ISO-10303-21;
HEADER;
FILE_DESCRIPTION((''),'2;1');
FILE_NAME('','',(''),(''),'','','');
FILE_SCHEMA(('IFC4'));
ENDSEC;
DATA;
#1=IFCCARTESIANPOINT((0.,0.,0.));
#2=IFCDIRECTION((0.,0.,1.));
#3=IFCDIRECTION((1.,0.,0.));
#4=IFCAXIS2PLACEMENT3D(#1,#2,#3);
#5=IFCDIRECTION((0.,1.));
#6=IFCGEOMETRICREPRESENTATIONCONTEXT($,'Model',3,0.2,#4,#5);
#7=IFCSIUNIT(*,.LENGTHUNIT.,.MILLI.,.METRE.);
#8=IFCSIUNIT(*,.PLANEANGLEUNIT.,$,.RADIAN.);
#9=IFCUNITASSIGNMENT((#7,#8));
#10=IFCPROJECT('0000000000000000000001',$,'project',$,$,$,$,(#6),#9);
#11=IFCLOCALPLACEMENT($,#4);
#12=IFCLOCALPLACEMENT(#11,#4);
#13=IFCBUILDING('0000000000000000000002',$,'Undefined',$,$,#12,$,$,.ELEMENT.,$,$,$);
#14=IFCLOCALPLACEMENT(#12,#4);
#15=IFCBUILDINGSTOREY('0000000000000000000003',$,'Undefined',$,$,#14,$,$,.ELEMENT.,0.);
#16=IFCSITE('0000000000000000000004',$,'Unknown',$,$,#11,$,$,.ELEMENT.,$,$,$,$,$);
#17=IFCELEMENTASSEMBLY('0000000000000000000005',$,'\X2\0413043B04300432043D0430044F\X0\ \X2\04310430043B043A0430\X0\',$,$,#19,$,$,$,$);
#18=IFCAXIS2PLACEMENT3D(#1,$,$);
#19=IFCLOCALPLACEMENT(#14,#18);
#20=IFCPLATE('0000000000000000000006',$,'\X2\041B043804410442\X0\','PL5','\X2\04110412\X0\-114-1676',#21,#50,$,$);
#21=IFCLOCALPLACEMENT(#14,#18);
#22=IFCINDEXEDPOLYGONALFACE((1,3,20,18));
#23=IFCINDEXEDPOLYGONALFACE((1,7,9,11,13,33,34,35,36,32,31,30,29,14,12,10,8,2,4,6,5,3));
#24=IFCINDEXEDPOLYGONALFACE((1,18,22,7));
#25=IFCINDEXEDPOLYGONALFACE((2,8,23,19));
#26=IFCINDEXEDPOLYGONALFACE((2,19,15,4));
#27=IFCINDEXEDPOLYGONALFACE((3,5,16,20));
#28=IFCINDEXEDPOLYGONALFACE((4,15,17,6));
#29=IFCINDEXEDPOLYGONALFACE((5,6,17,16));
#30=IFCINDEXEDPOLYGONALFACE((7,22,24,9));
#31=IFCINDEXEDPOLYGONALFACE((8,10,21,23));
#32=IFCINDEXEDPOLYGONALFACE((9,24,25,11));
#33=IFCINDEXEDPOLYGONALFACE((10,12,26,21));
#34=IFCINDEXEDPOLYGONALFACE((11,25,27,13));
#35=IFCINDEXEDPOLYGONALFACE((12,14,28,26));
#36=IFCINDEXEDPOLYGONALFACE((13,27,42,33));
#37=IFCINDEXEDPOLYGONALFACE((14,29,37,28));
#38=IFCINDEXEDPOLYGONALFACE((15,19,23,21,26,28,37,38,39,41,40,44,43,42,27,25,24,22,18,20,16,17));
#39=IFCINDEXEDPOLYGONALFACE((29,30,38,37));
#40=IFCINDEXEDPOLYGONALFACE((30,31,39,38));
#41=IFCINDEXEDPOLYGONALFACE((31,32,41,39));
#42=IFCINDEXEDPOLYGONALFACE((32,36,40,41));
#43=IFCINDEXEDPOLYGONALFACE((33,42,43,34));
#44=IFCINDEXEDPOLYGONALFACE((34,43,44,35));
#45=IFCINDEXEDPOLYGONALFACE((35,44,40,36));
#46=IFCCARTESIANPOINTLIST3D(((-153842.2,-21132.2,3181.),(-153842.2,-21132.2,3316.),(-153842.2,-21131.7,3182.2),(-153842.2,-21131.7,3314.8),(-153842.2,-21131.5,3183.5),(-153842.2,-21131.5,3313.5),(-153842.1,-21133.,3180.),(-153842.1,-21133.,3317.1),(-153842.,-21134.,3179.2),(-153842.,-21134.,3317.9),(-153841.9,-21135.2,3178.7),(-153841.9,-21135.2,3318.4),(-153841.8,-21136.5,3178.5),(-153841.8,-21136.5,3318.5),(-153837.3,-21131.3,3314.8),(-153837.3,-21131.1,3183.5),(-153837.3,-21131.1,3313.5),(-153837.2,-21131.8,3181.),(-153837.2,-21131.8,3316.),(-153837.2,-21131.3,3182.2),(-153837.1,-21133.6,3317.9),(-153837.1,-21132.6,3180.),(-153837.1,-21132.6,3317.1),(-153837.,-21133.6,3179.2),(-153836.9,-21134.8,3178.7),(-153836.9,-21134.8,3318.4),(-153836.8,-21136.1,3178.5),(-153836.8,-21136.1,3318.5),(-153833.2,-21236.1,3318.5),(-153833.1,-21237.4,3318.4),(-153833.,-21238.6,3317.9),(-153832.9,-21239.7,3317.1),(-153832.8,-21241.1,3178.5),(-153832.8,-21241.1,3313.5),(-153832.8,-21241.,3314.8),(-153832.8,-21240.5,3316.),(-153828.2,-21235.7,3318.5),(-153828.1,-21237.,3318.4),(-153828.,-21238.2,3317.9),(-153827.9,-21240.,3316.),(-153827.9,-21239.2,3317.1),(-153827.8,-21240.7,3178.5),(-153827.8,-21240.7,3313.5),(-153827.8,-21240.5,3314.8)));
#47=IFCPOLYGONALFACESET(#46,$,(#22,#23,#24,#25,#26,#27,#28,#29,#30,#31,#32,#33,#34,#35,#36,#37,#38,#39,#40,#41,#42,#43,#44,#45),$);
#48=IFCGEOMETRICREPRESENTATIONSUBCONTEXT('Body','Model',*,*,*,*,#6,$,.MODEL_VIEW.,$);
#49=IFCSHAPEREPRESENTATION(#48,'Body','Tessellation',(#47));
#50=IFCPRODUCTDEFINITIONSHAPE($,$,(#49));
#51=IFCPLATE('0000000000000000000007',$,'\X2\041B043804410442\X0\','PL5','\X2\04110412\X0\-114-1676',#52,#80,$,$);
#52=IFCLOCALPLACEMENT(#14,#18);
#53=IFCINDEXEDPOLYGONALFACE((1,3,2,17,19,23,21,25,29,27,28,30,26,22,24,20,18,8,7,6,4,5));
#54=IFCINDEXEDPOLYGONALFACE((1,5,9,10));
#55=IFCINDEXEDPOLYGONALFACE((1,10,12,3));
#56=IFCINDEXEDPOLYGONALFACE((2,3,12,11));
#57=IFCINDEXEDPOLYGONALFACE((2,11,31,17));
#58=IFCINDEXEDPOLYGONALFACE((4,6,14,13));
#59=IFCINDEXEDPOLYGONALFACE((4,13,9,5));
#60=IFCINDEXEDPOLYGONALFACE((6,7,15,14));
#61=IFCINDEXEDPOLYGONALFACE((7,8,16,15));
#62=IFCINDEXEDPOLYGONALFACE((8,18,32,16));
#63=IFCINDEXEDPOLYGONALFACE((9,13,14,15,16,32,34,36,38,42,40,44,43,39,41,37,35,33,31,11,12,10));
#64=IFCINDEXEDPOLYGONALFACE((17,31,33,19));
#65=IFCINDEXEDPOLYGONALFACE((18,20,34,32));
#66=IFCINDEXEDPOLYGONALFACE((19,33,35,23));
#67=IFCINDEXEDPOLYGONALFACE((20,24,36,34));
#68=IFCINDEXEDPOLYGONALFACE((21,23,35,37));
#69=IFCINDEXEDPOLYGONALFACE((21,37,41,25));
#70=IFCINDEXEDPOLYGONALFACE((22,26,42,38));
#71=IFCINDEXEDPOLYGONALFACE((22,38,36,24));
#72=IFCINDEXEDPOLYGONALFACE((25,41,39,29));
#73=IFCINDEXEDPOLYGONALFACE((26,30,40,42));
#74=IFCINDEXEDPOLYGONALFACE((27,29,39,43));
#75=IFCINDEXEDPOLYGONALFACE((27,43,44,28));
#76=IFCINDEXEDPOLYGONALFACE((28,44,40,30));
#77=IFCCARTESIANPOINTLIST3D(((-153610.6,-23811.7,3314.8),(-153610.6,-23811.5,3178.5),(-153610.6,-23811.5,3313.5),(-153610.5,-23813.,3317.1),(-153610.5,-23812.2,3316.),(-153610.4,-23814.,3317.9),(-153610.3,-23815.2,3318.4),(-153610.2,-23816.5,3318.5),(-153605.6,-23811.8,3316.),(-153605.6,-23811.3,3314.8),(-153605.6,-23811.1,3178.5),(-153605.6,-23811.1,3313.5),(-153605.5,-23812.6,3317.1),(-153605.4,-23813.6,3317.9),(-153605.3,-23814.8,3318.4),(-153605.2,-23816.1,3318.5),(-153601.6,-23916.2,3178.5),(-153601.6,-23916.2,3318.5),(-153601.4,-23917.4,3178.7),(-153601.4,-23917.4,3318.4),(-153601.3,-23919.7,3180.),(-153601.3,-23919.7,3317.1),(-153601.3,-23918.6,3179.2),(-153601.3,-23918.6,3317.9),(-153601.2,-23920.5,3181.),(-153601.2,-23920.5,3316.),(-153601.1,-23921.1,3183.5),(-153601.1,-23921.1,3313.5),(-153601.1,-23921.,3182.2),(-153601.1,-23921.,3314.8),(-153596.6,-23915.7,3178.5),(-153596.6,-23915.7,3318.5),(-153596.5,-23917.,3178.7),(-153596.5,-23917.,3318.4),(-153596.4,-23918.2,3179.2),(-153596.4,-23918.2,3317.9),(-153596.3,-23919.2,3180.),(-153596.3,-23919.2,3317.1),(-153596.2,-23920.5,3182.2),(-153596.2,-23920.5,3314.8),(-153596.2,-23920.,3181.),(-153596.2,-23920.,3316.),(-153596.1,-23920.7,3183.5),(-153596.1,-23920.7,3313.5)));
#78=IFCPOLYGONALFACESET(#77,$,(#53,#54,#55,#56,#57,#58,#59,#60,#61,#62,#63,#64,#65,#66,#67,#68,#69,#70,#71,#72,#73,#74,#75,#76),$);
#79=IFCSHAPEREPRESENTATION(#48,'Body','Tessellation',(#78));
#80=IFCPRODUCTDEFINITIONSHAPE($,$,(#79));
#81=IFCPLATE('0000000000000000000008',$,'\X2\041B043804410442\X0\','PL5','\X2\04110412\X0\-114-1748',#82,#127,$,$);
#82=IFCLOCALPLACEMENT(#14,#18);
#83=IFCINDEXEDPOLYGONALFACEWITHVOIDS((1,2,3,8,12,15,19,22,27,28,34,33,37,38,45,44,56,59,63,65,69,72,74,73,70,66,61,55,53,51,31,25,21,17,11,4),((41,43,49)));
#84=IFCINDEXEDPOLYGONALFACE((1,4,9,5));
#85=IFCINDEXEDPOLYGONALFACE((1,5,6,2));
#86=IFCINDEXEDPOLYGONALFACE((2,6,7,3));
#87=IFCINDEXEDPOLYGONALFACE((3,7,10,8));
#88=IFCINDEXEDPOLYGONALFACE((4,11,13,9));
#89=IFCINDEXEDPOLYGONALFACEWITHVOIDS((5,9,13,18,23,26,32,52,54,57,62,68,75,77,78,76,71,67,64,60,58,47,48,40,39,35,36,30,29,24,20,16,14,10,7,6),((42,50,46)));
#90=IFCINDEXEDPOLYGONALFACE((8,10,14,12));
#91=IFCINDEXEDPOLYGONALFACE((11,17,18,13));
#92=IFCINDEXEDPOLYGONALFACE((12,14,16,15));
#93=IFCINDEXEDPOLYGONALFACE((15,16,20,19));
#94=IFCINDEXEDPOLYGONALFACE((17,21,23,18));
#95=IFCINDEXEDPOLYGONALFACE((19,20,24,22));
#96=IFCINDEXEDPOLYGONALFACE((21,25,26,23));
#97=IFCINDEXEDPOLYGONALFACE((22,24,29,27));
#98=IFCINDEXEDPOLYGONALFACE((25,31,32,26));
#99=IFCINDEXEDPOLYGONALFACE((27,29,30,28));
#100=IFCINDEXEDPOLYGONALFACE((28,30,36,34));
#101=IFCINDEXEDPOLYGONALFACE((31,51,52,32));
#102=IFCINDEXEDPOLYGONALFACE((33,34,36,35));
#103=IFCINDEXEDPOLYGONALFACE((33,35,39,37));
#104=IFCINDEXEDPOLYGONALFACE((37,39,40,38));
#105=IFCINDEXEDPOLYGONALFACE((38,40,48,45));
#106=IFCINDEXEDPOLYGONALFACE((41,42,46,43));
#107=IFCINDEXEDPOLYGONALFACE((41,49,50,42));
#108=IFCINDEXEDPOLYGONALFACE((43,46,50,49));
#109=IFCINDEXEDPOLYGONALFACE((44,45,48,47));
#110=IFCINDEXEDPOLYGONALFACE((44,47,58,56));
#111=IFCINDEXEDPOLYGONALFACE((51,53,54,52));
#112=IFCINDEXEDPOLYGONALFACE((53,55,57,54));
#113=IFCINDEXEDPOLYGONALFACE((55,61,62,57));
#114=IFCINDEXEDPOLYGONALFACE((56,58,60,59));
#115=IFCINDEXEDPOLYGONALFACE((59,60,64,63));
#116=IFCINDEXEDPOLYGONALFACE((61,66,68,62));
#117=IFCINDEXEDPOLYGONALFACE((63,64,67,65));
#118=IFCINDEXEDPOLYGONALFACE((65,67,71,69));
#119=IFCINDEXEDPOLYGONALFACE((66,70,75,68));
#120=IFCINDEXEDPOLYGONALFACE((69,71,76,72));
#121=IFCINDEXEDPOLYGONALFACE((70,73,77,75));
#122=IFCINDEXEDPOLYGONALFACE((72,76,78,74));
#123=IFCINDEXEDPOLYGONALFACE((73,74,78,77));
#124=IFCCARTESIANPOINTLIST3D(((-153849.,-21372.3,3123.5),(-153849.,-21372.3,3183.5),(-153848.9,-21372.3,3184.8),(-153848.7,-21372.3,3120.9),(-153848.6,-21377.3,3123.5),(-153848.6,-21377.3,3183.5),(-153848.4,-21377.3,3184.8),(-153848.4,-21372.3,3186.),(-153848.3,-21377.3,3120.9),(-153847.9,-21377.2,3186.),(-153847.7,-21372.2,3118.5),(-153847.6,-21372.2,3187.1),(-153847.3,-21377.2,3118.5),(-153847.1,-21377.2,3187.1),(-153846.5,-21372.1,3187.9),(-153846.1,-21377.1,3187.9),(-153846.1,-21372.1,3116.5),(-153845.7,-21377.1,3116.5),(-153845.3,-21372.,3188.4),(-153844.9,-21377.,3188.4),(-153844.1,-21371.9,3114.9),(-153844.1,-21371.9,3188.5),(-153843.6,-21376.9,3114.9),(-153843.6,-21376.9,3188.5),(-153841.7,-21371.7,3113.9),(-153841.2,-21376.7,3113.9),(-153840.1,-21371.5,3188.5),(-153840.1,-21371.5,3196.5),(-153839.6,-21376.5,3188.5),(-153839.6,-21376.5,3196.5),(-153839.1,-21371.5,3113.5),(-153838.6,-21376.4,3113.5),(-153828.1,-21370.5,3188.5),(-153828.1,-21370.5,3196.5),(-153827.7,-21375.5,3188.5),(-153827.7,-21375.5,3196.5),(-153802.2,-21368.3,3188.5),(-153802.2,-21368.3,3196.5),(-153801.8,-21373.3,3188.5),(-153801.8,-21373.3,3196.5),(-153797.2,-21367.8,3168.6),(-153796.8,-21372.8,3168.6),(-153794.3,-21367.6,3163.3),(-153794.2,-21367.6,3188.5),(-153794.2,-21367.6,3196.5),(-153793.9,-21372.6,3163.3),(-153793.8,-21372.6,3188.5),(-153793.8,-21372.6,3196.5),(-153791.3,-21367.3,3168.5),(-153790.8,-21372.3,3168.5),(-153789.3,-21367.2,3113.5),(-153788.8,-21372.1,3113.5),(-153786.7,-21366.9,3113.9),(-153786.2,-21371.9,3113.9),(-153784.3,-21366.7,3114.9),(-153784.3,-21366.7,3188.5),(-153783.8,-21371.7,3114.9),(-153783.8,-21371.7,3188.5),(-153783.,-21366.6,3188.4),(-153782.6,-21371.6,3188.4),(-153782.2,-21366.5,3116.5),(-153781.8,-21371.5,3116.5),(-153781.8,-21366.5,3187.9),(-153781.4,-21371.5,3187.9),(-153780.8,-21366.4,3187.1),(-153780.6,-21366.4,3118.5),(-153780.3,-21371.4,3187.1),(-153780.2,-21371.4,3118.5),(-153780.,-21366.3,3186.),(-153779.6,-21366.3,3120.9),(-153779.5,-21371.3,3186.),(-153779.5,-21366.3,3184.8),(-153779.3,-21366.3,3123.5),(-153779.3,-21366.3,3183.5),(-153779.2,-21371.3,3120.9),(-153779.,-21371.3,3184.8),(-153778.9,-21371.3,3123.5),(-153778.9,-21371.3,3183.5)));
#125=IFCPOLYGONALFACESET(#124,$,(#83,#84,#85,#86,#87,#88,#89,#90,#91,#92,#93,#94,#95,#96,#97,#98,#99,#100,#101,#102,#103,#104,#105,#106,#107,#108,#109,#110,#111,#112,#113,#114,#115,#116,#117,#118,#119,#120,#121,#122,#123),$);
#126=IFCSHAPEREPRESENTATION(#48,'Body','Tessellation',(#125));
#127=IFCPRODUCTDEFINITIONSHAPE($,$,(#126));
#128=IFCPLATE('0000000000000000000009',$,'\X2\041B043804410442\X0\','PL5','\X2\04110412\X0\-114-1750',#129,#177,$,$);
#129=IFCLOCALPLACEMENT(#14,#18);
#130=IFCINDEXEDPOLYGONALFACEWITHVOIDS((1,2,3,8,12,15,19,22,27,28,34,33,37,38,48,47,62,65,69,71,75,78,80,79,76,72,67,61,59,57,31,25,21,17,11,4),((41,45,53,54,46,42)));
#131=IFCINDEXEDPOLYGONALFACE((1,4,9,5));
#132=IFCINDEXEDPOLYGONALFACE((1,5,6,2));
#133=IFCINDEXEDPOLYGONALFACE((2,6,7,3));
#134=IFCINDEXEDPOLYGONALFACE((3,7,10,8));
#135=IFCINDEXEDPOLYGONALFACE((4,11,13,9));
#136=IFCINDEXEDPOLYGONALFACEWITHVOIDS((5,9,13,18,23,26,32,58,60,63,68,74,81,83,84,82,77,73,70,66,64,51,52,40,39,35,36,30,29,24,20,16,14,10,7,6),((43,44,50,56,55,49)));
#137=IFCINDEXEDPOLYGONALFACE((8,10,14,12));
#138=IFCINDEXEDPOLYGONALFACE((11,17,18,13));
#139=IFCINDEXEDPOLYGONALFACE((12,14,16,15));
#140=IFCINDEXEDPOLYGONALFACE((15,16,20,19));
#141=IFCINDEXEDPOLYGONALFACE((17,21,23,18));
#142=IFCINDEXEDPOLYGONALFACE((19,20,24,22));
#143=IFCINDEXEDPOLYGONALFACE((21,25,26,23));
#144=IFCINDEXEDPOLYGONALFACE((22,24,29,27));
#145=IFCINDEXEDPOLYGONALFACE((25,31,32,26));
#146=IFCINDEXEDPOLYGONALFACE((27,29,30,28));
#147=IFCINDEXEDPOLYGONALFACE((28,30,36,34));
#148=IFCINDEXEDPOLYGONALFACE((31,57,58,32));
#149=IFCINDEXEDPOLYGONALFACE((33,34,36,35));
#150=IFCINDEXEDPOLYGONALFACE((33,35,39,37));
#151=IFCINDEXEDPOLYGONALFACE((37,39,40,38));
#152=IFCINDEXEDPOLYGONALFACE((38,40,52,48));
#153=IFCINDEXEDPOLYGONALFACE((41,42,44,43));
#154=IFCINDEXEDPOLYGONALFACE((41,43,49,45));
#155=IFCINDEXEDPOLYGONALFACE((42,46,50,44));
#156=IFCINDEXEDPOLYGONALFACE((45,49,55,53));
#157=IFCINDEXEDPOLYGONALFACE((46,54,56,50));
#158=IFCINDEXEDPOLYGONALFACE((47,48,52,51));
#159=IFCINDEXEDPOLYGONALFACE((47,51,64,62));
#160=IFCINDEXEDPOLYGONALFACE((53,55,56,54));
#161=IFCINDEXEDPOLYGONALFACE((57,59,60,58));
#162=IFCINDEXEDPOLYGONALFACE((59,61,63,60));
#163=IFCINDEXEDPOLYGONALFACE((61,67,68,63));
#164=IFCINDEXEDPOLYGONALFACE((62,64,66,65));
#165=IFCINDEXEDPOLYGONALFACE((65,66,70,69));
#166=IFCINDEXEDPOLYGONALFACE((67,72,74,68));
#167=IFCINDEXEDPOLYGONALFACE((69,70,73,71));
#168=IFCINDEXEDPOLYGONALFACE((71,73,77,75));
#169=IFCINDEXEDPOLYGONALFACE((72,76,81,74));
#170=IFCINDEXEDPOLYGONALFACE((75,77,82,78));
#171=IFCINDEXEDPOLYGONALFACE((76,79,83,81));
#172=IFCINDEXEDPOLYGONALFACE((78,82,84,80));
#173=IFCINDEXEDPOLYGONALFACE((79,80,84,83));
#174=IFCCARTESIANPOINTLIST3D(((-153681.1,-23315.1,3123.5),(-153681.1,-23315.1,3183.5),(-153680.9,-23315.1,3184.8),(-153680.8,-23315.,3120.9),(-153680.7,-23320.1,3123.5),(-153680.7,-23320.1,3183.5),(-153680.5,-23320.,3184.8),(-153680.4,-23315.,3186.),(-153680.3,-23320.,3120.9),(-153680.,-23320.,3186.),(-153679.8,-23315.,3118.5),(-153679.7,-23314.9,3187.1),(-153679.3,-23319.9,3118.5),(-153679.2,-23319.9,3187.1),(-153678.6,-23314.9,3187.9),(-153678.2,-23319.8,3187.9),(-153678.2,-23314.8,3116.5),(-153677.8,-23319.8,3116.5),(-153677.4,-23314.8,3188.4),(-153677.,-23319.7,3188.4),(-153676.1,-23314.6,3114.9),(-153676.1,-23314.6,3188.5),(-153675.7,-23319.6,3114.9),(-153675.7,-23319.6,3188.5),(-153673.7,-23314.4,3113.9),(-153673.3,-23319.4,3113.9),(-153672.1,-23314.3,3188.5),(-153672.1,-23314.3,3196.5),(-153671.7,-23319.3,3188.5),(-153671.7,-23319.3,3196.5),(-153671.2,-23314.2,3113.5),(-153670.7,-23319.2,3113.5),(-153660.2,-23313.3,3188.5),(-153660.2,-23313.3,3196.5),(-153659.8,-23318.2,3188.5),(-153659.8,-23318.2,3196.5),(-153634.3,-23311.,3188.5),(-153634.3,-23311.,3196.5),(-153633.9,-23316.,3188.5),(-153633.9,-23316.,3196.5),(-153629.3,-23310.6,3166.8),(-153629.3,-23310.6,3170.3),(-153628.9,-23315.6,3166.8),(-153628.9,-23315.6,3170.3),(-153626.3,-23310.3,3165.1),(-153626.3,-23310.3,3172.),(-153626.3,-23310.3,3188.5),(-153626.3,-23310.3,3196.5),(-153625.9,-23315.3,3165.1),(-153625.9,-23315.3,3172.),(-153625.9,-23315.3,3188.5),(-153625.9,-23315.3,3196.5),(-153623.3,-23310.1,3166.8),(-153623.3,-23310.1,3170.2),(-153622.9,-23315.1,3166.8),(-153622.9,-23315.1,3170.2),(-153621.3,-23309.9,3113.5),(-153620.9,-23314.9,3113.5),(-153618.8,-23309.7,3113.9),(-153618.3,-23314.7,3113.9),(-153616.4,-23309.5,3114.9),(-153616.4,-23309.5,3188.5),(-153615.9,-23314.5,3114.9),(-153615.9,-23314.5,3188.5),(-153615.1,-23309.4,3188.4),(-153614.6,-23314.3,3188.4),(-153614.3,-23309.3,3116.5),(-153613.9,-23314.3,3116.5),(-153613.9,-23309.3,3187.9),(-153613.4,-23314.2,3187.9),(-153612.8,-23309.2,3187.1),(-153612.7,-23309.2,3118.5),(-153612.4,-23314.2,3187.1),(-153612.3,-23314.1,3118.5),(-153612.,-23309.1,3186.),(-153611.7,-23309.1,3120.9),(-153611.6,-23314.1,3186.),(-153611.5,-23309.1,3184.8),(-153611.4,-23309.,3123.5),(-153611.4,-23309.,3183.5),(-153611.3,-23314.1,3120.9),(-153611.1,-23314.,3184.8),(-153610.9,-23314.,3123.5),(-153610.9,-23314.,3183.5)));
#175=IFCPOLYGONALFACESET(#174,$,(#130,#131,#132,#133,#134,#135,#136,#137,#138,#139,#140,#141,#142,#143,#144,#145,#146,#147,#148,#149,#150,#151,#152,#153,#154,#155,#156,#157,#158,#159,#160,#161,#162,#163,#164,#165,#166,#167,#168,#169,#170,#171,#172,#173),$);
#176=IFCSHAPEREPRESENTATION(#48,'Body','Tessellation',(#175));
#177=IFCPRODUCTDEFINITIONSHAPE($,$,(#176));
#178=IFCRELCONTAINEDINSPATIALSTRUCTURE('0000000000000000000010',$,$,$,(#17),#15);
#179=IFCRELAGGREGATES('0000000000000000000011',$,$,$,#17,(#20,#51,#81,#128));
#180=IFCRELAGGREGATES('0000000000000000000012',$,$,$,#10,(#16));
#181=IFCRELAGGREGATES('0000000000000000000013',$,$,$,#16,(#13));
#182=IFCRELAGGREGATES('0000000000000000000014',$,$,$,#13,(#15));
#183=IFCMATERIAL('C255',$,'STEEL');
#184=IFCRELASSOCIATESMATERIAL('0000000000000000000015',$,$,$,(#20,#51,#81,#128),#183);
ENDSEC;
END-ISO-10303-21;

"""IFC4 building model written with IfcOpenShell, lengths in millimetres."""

from ifc_helpers import new_model, si_unit, direction, frame, origin_with_axes, place, context, subcontext, project, spatial, line, arc, indexed_curve, outline, extrude, material, element, aggregate, save


model = new_model("IFC4")

# Units and contexts
model_context = context("Model", 3, precision=0.2, world=origin_with_axes(), true_north=direction((0.0, 1.0)))
body_context = subcontext(model_context, "Body", "Model", "MODEL_VIEW")
ifc_project = project(units=[si_unit("LENGTHUNIT", "METRE", prefix="MILLI"), si_unit("PLANEANGLEUNIT", "RADIAN")], contexts=[model_context])

# Site, building, storey
site_placement = place(None, origin_with_axes())
site = spatial("IfcSite", under=ifc_project, at=site_placement, Name="Unknown", CompositionType="ELEMENT")
building_placement = place(site_placement, origin_with_axes())
building = spatial("IfcBuilding", under=site, at=building_placement, Name="Undefined", CompositionType="ELEMENT")
storey_placement = place(building_placement, origin_with_axes())
storey = spatial("IfcBuildingStorey", under=building, at=storey_placement, Name="Undefined", CompositionType="ELEMENT", Elevation=0.0)

# Element assembly, plates, voiding features
ifc_material_1 = material(Name="C255", Category="STEEL")
assembly_1_placement = place(storey_placement, frame((-153597.5, -23933.9, 3248.5), z_axis=(-0.996285, -0.086114, -0.000024), x_axis=(-0.086114, 0.996285, 0.0)))
assembly_1 = element("IfcElementAssembly", 1, at=assembly_1_placement, inside=storey, Name="Главная балка")
plate_1_placement = place(assembly_1_placement, frame((2813.0, -70.0, 0.0), z_axis=(0.0, 0.0, 1.0), x_axis=(0.0, 1.0, 0.0)))
plate_1 = element("IfcPlate", 2, at=plate_1_placement, material=ifc_material_1, Name="Лист", Description="PL5", ObjectType="БВ-114-1676", context=body_context, shape_type="SolidModel", body=[
    extrude(outline(indexed_curve([(0.0, 5.0), (1.5, 1.5), (5.0, 0.0), (135.0, 0.0), (138.5, 1.5), (140.0, 5.0), (140.0, 110.0), (5.0, 110.0), (1.5, 108.5), (0.0, 105.0)], segments=[arc(1, 2, 3), line(3, 4), arc(4, 5, 6), line(6, 7, 8), arc(8, 9, 10), line(10, 1)])), frame((0.0, 0.0, 2.5), z_axis=(0.0, 0.0, 1.0), x_axis=(1.0, 0.0, 0.0)), (0.0, 0.0, -1.0), 5.0),
])
plate_2_placement = place(assembly_1_placement, frame((13.0, -70.0, 0.0), z_axis=(0.0, 0.0, -1.0), x_axis=(0.0, 1.0, 0.0)))
plate_2 = element("IfcPlate", 3, at=plate_2_placement, material=ifc_material_1, Name="Лист", Description="PL5", ObjectType="БВ-114-1676", context=body_context, shape_type="SolidModel", body=[
    extrude(outline(indexed_curve([(0.0, 5.0), (1.5, 1.5), (5.0, 0.0), (135.0, 0.0), (138.5, 1.5), (140.0, 5.0), (140.0, 110.0), (5.0, 110.0), (1.5, 108.5), (0.0, 105.0)], segments=[arc(1, 2, 3), line(3, 4), arc(4, 5, 6), line(6, 7, 8), arc(8, 9, 10), line(10, 1)])), frame((0.0, 0.0, 2.5), z_axis=(0.0, 0.0, 1.0), x_axis=(1.0, 0.0, 0.0)), (0.0, 0.0, -1.0), 5.0),
])
plate_3_placement = place(assembly_1_placement, frame((2571.2, 135.0, -40.0), z_axis=(1.0, 0.000054, 0.0), x_axis=(0.0, -0.000054, 1.0)))
plate_3 = element("IfcPlate", 4, at=plate_3_placement, material=ifc_material_1, Name="Лист", Description="PL5", ObjectType="БВ-114-1748", context=body_context, shape_type="SolidModel", body=[
    extrude(outline(indexed_curve([(0.0, 10.0), (2.9, 2.9), (10.0, 0.0), (60.0, 0.0), (67.1, 2.9), (70.0, 10.0), (70.0, 70.0), (68.5, 73.5), (65.0, 75.0), (61.0, 75.0), (61.0, 83.0), (49.0, 83.0), (49.0, 75.0), (23.0, 75.0), (23.0, 83.0), (15.0, 83.0), (15.0, 75.0), (5.0, 75.0), (1.5, 73.5), (0.0, 70.0)], segments=[arc(1, 2, 3), line(3, 4), arc(4, 5, 6), line(6, 7), arc(7, 8, 9), line(9, 10, 11, 12, 13, 14, 15, 16, 17, 18), arc(18, 19, 20), line(20, 1)])), frame((0.0, 0.0, 2.5), z_axis=(0.0, 0.0, 1.0), x_axis=(1.0, 0.0, 0.0)), (0.0, 0.0, -1.0), 5.0),
])
voiding_feature_1_placement = place(plate_3_placement, frame((15.0, 55.0, 10.0), z_axis=(0.007997, -0.999968, -0.000026), x_axis=(0.0, 0.000026, -1.0)))
element("IfcVoidingFeature", 5, at=voiding_feature_1_placement, cuts=plate_3, Name="Балка", ObjectType="(?)", PredefinedType="HOLE", context=body_context, shape_type="SolidModel", body=[
    extrude(outline(indexed_curve([(0.0, -3.0), (5.2, 0.0), (0.0, 3.0)], segments=[line(1, 2, 3, 1)])), frame((0.0, 0.0, 0.0), z_axis=(-1.0, 0.0, 0.0), x_axis=(0.0, 0.0, 1.0)), (0.0, 0.0, -1.0), 20.0),
])
plate_4_placement = place(assembly_1_placement, frame((621.2, 135.0, -40.0), z_axis=(1.0, 0.000054, 0.0), x_axis=(0.0, -0.000054, 1.0)))
plate_4 = element("IfcPlate", 6, at=plate_4_placement, material=ifc_material_1, Name="Лист", Description="PL5", ObjectType="БВ-114-1750", context=body_context, shape_type="SolidModel", body=[
    extrude(outline(indexed_curve([(0.0, 10.0), (2.9, 2.9), (10.0, 0.0), (60.0, 0.0), (67.1, 2.9), (70.0, 10.0), (70.0, 70.0), (68.5, 73.5), (65.0, 75.0), (61.0, 75.0), (61.0, 83.0), (49.0, 83.0), (49.0, 75.0), (23.0, 75.0), (23.0, 83.0), (15.0, 83.0), (15.0, 75.0), (5.0, 75.0), (1.5, 73.5), (0.0, 70.0)], segments=[arc(1, 2, 3), line(3, 4), arc(4, 5, 6), line(6, 7), arc(7, 8, 9), line(9, 10, 11, 12, 13, 14, 15, 16, 17, 18), arc(18, 19, 20), line(20, 1)])), frame((0.0, 0.0, 2.5), z_axis=(0.0, 0.0, 1.0), x_axis=(1.0, 0.0, 0.0)), (0.0, 0.0, -1.0), 5.0),
])
voiding_feature_2_placement = place(plate_4_placement, frame((15.0, 55.0, 10.0), z_axis=(0.007997, -0.999968, -0.000026), x_axis=(0.0, 0.000026, -1.0)))
element("IfcVoidingFeature", 7, at=voiding_feature_2_placement, cuts=plate_4, Name="Балка", ObjectType="(?)", PredefinedType="HOLE", context=body_context, shape_type="SolidModel", body=[
    extrude(outline(indexed_curve([(1.7, -3.0), (3.5, 0.0), (1.7, 3.0), (-1.7, 3.0), (-3.5, 0.0), (-1.7, -3.0)], segments=[line(1, 2, 3, 4, 5, 6, 1)])), frame((0.0, 0.0, 0.0), z_axis=(-1.0, 0.0, 0.0), x_axis=(0.0, 0.0, 1.0)), (0.0, 0.0, -1.0), 20.0),
])
aggregate(assembly_1, [plate_1, plate_2, plate_3, plate_4])

save(model, "model.ifc")
